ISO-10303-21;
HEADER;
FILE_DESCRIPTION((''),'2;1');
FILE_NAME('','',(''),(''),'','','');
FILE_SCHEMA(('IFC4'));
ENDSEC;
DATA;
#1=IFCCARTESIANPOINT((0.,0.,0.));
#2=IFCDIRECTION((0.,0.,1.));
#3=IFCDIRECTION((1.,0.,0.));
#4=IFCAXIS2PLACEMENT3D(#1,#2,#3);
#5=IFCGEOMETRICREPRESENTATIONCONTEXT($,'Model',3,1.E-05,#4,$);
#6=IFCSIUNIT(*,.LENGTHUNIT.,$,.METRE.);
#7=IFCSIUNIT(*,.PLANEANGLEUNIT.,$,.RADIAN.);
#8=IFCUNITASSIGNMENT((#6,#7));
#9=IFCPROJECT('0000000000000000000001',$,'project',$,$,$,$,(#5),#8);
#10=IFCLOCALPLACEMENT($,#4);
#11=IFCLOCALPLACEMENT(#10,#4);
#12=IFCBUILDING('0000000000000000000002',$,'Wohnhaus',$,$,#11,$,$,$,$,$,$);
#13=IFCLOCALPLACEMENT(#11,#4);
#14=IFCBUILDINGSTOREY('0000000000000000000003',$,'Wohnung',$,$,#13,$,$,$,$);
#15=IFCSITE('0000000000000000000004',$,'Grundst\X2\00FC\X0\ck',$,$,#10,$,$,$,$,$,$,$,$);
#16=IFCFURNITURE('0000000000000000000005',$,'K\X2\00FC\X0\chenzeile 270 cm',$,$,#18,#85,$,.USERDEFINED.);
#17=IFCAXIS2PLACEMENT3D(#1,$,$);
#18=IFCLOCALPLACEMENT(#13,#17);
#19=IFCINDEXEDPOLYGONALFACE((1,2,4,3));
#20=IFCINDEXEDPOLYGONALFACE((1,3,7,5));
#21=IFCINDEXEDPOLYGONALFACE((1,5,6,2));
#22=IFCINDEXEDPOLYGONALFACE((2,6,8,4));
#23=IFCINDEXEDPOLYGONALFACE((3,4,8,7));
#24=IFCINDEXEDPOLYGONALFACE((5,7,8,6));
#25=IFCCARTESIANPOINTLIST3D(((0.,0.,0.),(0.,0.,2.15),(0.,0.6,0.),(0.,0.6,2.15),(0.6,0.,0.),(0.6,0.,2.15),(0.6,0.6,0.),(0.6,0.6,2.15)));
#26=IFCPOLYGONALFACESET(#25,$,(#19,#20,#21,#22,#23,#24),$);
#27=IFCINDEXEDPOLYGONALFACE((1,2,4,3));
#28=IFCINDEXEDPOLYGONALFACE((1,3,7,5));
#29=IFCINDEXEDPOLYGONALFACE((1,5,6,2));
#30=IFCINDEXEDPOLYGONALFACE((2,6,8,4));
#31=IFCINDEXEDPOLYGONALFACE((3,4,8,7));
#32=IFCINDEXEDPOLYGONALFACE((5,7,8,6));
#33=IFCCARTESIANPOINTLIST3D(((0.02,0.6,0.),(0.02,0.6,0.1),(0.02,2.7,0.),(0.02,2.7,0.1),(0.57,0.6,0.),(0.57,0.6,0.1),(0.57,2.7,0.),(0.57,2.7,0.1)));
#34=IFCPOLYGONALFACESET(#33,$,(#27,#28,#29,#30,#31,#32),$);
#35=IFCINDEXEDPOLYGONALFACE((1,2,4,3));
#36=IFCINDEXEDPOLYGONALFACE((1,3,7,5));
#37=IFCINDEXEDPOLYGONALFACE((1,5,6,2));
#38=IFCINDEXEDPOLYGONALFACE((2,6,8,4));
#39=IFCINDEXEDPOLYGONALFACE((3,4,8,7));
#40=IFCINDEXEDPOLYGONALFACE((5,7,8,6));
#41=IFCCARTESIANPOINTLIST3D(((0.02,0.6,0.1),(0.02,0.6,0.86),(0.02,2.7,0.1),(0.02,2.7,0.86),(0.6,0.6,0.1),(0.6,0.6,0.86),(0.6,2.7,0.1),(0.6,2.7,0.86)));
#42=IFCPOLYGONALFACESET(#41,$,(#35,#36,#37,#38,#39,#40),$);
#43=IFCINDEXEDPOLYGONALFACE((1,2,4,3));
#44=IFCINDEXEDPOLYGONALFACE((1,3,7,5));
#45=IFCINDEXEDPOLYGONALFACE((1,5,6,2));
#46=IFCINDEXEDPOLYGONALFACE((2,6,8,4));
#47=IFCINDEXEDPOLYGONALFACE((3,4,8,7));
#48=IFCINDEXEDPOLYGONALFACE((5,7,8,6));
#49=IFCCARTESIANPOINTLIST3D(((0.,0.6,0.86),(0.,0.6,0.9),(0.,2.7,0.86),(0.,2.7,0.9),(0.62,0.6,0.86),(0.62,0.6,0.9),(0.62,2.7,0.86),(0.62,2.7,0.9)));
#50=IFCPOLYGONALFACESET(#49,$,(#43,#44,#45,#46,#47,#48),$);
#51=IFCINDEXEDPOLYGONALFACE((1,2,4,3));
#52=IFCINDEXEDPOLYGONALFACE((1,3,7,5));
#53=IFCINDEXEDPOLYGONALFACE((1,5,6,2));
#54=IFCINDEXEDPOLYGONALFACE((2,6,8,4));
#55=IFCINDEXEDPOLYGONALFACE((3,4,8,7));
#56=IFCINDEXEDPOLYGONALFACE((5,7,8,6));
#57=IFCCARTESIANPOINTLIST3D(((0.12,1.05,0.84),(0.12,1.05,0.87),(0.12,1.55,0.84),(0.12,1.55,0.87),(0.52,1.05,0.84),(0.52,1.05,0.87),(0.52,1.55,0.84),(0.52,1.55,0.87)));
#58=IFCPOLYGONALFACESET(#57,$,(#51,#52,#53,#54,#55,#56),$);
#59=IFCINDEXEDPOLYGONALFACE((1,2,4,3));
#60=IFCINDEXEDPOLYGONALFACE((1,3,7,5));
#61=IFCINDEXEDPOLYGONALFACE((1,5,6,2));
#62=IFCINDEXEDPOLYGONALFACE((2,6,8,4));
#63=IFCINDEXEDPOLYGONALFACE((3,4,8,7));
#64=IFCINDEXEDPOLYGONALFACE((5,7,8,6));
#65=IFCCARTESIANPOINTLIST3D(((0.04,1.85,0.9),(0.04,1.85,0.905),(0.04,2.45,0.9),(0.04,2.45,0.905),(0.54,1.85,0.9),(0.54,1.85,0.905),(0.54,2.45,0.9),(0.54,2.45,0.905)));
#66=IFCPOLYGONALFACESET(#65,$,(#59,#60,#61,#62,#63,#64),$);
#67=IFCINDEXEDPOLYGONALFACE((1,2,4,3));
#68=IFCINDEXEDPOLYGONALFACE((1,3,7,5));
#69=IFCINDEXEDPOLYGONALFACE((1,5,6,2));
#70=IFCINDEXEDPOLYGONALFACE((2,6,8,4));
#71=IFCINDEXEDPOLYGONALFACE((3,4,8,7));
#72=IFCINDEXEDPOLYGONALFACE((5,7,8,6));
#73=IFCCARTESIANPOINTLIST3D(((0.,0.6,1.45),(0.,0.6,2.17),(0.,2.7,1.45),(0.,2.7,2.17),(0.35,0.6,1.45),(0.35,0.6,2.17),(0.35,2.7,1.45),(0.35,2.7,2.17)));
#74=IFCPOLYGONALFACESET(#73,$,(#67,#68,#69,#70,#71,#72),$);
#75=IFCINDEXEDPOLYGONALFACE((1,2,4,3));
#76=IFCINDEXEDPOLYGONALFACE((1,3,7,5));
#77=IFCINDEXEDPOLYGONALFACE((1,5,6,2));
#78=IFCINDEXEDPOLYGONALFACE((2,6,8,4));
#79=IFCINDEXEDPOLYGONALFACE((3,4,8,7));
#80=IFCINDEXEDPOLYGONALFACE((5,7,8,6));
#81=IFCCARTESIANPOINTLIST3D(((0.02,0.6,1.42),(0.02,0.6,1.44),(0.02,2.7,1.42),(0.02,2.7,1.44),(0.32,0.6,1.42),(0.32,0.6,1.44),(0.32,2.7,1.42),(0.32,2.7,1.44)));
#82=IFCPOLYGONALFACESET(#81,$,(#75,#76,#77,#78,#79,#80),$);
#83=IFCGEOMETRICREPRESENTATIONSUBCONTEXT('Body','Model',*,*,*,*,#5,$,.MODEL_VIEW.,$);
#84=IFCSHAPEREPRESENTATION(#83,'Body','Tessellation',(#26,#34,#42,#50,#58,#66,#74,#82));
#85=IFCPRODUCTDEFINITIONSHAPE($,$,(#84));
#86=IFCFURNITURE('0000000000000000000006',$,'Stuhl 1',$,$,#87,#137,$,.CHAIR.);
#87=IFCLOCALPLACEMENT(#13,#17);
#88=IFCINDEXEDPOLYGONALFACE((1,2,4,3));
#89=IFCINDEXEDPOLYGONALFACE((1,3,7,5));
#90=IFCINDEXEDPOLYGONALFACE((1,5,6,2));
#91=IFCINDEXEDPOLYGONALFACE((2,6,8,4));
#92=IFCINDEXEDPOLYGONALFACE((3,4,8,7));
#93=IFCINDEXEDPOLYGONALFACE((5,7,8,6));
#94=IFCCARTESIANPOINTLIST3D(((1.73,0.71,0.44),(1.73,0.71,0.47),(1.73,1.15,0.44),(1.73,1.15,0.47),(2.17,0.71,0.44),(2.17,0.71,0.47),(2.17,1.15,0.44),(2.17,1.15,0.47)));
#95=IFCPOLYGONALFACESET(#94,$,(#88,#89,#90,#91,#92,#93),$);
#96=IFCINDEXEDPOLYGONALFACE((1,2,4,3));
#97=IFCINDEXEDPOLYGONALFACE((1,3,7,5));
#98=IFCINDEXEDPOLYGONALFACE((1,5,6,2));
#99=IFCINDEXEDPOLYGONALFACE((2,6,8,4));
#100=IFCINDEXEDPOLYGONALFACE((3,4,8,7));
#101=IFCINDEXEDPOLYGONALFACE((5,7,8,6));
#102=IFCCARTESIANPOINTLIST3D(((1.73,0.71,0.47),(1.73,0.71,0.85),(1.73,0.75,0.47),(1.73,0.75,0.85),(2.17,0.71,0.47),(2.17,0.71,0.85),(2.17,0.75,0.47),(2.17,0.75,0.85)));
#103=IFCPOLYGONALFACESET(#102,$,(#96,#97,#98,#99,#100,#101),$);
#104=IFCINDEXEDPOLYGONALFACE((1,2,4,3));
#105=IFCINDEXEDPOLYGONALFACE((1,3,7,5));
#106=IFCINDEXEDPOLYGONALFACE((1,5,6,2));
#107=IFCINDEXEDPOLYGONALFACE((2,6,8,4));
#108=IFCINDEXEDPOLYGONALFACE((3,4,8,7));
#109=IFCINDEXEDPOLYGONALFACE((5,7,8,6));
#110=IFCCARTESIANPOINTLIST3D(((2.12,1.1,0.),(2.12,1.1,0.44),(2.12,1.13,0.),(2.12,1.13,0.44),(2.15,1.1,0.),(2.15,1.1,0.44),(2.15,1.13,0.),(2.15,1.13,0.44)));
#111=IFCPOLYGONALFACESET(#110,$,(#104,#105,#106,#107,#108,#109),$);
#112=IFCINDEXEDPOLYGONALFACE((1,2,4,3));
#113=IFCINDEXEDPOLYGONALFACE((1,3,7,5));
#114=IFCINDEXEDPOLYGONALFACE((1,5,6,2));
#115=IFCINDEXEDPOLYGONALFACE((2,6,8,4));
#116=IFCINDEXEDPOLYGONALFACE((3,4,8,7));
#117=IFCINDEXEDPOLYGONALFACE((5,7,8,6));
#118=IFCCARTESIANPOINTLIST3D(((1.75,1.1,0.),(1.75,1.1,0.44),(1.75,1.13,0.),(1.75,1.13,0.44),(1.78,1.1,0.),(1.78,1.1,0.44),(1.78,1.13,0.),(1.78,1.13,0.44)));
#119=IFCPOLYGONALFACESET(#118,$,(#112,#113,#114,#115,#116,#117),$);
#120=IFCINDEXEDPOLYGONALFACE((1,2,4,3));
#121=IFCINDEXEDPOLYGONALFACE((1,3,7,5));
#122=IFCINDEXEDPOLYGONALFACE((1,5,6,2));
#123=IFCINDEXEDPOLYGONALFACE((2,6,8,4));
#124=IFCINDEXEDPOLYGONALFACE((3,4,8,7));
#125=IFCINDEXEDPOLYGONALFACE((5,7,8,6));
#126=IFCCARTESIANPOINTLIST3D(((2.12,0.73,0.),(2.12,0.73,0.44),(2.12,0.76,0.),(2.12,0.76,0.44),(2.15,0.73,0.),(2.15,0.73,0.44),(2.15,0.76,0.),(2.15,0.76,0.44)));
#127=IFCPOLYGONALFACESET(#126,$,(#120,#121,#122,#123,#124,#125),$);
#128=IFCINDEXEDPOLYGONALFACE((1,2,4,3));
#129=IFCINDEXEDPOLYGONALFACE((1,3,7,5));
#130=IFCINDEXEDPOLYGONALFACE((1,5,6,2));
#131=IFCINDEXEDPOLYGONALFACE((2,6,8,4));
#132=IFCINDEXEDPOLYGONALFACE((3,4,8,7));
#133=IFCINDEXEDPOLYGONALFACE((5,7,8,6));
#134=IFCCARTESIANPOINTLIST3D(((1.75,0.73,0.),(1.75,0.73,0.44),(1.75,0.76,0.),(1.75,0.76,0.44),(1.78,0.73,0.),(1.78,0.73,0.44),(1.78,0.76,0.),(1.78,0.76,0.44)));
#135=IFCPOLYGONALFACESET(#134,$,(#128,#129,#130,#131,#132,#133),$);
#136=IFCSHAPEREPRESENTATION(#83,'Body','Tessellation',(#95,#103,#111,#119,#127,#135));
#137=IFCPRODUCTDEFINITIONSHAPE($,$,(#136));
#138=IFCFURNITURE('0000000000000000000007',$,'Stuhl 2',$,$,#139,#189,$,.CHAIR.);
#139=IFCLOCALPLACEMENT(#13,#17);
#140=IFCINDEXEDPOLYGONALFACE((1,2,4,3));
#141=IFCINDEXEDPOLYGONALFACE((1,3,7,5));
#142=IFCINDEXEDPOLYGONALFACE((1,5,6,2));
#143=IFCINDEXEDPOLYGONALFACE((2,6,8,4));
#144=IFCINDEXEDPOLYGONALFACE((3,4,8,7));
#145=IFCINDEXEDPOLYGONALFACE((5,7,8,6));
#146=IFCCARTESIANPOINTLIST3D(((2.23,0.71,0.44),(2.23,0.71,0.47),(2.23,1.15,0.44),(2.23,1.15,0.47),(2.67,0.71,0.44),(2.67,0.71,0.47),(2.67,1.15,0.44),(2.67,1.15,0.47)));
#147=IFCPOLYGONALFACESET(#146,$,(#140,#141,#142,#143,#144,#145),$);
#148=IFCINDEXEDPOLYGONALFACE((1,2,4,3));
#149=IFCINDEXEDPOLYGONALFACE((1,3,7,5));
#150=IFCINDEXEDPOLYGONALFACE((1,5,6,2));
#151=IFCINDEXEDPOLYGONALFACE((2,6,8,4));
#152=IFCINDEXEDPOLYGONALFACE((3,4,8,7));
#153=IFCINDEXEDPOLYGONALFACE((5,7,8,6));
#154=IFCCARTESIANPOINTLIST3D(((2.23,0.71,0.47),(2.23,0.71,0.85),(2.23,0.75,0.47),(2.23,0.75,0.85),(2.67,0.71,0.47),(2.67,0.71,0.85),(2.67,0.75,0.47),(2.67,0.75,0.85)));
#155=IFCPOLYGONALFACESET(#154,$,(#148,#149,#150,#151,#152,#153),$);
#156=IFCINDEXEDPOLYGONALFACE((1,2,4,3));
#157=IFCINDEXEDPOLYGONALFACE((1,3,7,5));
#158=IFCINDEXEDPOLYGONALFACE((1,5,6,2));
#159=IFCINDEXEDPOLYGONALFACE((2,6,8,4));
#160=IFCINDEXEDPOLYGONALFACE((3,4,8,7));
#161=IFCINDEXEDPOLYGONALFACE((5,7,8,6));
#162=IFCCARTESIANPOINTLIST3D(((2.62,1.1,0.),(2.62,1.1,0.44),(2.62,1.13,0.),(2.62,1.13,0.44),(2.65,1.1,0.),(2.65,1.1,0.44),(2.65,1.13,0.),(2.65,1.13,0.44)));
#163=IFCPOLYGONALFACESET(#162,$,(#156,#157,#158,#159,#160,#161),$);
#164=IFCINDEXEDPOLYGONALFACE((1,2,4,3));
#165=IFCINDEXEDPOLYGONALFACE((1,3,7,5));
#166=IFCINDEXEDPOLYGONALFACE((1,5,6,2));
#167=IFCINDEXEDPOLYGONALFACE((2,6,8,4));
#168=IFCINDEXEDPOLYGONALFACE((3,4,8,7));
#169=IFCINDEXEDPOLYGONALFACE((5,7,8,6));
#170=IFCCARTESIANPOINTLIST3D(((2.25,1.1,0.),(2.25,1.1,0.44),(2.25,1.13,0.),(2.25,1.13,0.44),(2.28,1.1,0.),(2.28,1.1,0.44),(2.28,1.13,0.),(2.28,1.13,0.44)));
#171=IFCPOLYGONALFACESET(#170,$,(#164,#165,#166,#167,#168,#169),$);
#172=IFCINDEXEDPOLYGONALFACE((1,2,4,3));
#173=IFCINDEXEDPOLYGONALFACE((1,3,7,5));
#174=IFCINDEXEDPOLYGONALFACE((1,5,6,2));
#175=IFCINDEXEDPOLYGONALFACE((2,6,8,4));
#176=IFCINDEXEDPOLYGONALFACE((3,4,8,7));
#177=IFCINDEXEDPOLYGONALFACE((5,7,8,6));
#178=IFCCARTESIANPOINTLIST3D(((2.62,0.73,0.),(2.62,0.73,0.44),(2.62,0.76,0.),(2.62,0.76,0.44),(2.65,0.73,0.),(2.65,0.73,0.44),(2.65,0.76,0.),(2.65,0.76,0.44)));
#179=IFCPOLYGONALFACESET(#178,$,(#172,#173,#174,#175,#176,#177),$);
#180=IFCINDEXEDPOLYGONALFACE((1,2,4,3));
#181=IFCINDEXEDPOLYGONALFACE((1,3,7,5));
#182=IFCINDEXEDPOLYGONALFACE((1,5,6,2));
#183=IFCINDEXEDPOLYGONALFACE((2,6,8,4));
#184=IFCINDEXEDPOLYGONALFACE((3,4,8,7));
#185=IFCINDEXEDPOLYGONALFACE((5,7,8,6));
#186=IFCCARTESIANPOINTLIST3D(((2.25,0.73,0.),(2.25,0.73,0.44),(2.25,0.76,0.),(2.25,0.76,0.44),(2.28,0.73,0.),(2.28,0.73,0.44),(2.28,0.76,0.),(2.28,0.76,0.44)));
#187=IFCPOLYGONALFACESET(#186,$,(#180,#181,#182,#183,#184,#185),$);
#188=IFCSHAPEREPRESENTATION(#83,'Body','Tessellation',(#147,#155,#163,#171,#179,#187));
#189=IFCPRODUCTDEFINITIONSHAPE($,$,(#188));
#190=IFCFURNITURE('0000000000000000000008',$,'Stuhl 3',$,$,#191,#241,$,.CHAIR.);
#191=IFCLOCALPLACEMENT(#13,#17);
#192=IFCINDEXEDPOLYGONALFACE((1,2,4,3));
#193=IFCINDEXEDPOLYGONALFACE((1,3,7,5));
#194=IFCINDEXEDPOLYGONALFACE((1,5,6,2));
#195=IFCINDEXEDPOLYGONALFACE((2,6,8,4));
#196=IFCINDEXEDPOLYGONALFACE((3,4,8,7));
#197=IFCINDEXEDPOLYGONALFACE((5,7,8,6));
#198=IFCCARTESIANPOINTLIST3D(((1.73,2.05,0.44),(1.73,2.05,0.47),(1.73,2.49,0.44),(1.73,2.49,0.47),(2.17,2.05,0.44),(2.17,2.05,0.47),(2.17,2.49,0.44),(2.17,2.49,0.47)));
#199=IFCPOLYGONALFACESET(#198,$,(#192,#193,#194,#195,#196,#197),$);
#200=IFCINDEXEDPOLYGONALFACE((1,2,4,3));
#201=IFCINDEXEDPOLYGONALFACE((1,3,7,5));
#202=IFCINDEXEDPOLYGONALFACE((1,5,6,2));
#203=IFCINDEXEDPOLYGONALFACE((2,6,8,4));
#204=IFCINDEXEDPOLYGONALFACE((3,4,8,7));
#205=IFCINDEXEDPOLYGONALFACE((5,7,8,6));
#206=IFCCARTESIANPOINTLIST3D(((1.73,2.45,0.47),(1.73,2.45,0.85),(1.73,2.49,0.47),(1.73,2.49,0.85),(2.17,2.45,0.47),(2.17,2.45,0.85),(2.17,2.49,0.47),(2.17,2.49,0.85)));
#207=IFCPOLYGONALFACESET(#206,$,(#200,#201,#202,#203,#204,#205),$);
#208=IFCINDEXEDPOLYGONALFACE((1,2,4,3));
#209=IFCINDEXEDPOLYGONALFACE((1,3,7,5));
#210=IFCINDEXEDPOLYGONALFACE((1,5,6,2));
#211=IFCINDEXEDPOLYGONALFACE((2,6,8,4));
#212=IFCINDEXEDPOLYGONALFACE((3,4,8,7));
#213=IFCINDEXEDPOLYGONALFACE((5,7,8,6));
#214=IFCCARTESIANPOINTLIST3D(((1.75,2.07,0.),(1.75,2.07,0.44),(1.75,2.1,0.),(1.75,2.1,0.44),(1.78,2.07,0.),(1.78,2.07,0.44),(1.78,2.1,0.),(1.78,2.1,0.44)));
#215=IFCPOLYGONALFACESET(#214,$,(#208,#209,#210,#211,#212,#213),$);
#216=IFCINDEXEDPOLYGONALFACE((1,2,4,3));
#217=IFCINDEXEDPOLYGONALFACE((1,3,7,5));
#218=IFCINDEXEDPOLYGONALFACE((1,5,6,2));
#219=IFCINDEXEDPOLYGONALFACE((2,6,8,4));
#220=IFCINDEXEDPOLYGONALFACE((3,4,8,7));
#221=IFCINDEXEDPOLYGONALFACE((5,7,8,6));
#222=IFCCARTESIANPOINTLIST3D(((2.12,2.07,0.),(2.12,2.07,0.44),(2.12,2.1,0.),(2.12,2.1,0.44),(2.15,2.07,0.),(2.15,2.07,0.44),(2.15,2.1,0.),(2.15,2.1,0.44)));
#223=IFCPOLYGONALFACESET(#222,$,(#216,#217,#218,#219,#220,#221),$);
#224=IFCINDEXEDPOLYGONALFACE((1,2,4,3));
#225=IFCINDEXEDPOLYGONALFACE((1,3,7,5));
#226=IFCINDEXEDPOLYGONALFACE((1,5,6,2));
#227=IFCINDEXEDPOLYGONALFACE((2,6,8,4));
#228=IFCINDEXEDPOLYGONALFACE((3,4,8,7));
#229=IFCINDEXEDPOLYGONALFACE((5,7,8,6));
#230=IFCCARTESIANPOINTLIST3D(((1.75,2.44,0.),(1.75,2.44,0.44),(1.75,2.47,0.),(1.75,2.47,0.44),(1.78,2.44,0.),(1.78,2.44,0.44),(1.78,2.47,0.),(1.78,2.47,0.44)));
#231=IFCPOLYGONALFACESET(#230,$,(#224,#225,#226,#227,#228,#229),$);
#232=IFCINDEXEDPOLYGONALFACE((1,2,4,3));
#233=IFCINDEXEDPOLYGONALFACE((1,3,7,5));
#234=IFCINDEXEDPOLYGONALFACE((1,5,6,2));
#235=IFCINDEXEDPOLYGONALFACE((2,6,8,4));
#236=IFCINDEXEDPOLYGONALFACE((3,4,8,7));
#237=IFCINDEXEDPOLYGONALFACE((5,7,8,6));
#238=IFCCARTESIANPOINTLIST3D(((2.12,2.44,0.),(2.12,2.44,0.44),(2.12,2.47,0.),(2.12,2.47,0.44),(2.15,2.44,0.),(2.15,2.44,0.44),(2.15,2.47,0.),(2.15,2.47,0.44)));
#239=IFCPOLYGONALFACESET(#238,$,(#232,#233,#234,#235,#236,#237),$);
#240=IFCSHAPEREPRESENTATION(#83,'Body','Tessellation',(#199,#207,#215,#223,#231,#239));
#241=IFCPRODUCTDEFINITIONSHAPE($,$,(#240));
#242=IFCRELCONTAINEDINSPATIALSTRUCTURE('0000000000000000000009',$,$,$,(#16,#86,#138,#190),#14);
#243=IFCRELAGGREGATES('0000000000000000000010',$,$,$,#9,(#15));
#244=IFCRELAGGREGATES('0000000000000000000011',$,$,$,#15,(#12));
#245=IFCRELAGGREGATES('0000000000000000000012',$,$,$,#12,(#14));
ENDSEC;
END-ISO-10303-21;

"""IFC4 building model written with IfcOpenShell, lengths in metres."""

from ifc_helpers import new_model, si_unit, frame, frame_2d, origin, origin_with_axes, place, context, subcontext, project, spatial, rectangle, extrude, element, save


model = new_model("IFC4")

# Units and contexts
model_context = context("Model", 3, precision=1e-05, world=origin_with_axes())
body_context = subcontext(model_context, "Body", "Model", "MODEL_VIEW")
ifc_project = project(units=[si_unit("LENGTHUNIT", "METRE"), si_unit("PLANEANGLEUNIT", "RADIAN")], contexts=[model_context])

# Site, building, storey
site_placement = place(None, origin_with_axes())
site = spatial("IfcSite", under=ifc_project, at=site_placement, Name="Grundstück")
building_placement = place(site_placement, origin_with_axes())
building = spatial("IfcBuilding", under=site, at=building_placement, Name="Wohnhaus")
storey_placement = place(building_placement, origin_with_axes())
storey = spatial("IfcBuildingStorey", under=building, at=storey_placement, Name="Wohnung")

# Furniture
furniture_1_placement = place(storey_placement, frame((0.62, 0.0, 0.0), z_axis=(0.0, 0.0, 1.0), x_axis=(0.0, 1.0, 0.0)))
element("IfcFurniture", 1, at=furniture_1_placement, inside=storey, Name="Küchenzeile 270 cm", PredefinedType="USERDEFINED", context=body_context, shape_type="SweptSolid", body=[
    extrude(rectangle(XDim=0.6, YDim=0.6, at=frame_2d((0.3, 0.32))), origin(), (0.0, 0.0, 1.0), 2.15),
    extrude(rectangle(XDim=2.1, YDim=0.55, at=frame_2d((1.65, 0.325))), origin(), (0.0, 0.0, 1.0), 0.1),
    extrude(rectangle(XDim=2.1, YDim=0.58, at=frame_2d((1.65, 0.31))), frame((0.0, 0.0, 0.1)), (0.0, 0.0, 1.0), 0.76),
    extrude(rectangle(XDim=2.1, YDim=0.62, at=frame_2d((1.65, 0.31))), frame((0.0, 0.0, 0.86)), (0.0, 0.0, 1.0), 0.04),
    extrude(rectangle(XDim=0.5, YDim=0.4, at=frame_2d((1.3, 0.3))), frame((0.0, 0.0, 0.84)), (0.0, 0.0, 1.0), 0.03),
    extrude(rectangle(XDim=0.6, YDim=0.5, at=frame_2d((2.15, 0.33))), frame((0.0, 0.0, 0.9)), (0.0, 0.0, 1.0), 0.005),
    extrude(rectangle(XDim=2.1, YDim=0.35, at=frame_2d((1.65, 0.445))), frame((0.0, 0.0, 1.45)), (0.0, 0.0, 1.0), 0.72),
    extrude(rectangle(XDim=2.1, YDim=0.3, at=frame_2d((1.65, 0.45))), frame((0.0, 0.0, 1.42)), (0.0, 0.0, 1.0), 0.02),
])
for number, where, z_axis, x_axis, name in (
    (2, (2.17, 1.15, 0.0), (0.0, 0.0, 1.0), (-1.0, 0.0, 0.0), "Stuhl 1"),
    (3, (2.67, 1.15, 0.0), (0.0, 0.0, 1.0), (-1.0, 0.0, 0.0), "Stuhl 2"),
    (4, (1.73, 2.05, 0.0), (0.0, 0.0, 1.0), (1.0, 0.0, 0.0), "Stuhl 3"),
):
    element("IfcFurniture", number, at=place(storey_placement, frame(where, z_axis=z_axis, x_axis=x_axis)), inside=storey, Name=name, PredefinedType="CHAIR", context=body_context, shape_type="SweptSolid", body=[
        extrude(rectangle(XDim=0.44, YDim=0.44, at=frame_2d((0.22, 0.22))), frame((0.0, 0.0, 0.44)), (0.0, 0.0, 1.0), 0.03),
        extrude(rectangle(XDim=0.44, YDim=0.04, at=frame_2d((0.22, 0.42))), frame((0.0, 0.0, 0.47)), (0.0, 0.0, 1.0), 0.38),
        extrude(rectangle(XDim=0.03, YDim=0.03, at=frame_2d((0.035, 0.035))), origin(), (0.0, 0.0, 1.0), 0.44),
        extrude(rectangle(XDim=0.03, YDim=0.03, at=frame_2d((0.405, 0.035))), origin(), (0.0, 0.0, 1.0), 0.44),
        extrude(rectangle(XDim=0.03, YDim=0.03, at=frame_2d((0.035, 0.405))), origin(), (0.0, 0.0, 1.0), 0.44),
        extrude(rectangle(XDim=0.03, YDim=0.03, at=frame_2d((0.405, 0.405))), origin(), (0.0, 0.0, 1.0), 0.44),
    ])

save(model, "model.ifc")
